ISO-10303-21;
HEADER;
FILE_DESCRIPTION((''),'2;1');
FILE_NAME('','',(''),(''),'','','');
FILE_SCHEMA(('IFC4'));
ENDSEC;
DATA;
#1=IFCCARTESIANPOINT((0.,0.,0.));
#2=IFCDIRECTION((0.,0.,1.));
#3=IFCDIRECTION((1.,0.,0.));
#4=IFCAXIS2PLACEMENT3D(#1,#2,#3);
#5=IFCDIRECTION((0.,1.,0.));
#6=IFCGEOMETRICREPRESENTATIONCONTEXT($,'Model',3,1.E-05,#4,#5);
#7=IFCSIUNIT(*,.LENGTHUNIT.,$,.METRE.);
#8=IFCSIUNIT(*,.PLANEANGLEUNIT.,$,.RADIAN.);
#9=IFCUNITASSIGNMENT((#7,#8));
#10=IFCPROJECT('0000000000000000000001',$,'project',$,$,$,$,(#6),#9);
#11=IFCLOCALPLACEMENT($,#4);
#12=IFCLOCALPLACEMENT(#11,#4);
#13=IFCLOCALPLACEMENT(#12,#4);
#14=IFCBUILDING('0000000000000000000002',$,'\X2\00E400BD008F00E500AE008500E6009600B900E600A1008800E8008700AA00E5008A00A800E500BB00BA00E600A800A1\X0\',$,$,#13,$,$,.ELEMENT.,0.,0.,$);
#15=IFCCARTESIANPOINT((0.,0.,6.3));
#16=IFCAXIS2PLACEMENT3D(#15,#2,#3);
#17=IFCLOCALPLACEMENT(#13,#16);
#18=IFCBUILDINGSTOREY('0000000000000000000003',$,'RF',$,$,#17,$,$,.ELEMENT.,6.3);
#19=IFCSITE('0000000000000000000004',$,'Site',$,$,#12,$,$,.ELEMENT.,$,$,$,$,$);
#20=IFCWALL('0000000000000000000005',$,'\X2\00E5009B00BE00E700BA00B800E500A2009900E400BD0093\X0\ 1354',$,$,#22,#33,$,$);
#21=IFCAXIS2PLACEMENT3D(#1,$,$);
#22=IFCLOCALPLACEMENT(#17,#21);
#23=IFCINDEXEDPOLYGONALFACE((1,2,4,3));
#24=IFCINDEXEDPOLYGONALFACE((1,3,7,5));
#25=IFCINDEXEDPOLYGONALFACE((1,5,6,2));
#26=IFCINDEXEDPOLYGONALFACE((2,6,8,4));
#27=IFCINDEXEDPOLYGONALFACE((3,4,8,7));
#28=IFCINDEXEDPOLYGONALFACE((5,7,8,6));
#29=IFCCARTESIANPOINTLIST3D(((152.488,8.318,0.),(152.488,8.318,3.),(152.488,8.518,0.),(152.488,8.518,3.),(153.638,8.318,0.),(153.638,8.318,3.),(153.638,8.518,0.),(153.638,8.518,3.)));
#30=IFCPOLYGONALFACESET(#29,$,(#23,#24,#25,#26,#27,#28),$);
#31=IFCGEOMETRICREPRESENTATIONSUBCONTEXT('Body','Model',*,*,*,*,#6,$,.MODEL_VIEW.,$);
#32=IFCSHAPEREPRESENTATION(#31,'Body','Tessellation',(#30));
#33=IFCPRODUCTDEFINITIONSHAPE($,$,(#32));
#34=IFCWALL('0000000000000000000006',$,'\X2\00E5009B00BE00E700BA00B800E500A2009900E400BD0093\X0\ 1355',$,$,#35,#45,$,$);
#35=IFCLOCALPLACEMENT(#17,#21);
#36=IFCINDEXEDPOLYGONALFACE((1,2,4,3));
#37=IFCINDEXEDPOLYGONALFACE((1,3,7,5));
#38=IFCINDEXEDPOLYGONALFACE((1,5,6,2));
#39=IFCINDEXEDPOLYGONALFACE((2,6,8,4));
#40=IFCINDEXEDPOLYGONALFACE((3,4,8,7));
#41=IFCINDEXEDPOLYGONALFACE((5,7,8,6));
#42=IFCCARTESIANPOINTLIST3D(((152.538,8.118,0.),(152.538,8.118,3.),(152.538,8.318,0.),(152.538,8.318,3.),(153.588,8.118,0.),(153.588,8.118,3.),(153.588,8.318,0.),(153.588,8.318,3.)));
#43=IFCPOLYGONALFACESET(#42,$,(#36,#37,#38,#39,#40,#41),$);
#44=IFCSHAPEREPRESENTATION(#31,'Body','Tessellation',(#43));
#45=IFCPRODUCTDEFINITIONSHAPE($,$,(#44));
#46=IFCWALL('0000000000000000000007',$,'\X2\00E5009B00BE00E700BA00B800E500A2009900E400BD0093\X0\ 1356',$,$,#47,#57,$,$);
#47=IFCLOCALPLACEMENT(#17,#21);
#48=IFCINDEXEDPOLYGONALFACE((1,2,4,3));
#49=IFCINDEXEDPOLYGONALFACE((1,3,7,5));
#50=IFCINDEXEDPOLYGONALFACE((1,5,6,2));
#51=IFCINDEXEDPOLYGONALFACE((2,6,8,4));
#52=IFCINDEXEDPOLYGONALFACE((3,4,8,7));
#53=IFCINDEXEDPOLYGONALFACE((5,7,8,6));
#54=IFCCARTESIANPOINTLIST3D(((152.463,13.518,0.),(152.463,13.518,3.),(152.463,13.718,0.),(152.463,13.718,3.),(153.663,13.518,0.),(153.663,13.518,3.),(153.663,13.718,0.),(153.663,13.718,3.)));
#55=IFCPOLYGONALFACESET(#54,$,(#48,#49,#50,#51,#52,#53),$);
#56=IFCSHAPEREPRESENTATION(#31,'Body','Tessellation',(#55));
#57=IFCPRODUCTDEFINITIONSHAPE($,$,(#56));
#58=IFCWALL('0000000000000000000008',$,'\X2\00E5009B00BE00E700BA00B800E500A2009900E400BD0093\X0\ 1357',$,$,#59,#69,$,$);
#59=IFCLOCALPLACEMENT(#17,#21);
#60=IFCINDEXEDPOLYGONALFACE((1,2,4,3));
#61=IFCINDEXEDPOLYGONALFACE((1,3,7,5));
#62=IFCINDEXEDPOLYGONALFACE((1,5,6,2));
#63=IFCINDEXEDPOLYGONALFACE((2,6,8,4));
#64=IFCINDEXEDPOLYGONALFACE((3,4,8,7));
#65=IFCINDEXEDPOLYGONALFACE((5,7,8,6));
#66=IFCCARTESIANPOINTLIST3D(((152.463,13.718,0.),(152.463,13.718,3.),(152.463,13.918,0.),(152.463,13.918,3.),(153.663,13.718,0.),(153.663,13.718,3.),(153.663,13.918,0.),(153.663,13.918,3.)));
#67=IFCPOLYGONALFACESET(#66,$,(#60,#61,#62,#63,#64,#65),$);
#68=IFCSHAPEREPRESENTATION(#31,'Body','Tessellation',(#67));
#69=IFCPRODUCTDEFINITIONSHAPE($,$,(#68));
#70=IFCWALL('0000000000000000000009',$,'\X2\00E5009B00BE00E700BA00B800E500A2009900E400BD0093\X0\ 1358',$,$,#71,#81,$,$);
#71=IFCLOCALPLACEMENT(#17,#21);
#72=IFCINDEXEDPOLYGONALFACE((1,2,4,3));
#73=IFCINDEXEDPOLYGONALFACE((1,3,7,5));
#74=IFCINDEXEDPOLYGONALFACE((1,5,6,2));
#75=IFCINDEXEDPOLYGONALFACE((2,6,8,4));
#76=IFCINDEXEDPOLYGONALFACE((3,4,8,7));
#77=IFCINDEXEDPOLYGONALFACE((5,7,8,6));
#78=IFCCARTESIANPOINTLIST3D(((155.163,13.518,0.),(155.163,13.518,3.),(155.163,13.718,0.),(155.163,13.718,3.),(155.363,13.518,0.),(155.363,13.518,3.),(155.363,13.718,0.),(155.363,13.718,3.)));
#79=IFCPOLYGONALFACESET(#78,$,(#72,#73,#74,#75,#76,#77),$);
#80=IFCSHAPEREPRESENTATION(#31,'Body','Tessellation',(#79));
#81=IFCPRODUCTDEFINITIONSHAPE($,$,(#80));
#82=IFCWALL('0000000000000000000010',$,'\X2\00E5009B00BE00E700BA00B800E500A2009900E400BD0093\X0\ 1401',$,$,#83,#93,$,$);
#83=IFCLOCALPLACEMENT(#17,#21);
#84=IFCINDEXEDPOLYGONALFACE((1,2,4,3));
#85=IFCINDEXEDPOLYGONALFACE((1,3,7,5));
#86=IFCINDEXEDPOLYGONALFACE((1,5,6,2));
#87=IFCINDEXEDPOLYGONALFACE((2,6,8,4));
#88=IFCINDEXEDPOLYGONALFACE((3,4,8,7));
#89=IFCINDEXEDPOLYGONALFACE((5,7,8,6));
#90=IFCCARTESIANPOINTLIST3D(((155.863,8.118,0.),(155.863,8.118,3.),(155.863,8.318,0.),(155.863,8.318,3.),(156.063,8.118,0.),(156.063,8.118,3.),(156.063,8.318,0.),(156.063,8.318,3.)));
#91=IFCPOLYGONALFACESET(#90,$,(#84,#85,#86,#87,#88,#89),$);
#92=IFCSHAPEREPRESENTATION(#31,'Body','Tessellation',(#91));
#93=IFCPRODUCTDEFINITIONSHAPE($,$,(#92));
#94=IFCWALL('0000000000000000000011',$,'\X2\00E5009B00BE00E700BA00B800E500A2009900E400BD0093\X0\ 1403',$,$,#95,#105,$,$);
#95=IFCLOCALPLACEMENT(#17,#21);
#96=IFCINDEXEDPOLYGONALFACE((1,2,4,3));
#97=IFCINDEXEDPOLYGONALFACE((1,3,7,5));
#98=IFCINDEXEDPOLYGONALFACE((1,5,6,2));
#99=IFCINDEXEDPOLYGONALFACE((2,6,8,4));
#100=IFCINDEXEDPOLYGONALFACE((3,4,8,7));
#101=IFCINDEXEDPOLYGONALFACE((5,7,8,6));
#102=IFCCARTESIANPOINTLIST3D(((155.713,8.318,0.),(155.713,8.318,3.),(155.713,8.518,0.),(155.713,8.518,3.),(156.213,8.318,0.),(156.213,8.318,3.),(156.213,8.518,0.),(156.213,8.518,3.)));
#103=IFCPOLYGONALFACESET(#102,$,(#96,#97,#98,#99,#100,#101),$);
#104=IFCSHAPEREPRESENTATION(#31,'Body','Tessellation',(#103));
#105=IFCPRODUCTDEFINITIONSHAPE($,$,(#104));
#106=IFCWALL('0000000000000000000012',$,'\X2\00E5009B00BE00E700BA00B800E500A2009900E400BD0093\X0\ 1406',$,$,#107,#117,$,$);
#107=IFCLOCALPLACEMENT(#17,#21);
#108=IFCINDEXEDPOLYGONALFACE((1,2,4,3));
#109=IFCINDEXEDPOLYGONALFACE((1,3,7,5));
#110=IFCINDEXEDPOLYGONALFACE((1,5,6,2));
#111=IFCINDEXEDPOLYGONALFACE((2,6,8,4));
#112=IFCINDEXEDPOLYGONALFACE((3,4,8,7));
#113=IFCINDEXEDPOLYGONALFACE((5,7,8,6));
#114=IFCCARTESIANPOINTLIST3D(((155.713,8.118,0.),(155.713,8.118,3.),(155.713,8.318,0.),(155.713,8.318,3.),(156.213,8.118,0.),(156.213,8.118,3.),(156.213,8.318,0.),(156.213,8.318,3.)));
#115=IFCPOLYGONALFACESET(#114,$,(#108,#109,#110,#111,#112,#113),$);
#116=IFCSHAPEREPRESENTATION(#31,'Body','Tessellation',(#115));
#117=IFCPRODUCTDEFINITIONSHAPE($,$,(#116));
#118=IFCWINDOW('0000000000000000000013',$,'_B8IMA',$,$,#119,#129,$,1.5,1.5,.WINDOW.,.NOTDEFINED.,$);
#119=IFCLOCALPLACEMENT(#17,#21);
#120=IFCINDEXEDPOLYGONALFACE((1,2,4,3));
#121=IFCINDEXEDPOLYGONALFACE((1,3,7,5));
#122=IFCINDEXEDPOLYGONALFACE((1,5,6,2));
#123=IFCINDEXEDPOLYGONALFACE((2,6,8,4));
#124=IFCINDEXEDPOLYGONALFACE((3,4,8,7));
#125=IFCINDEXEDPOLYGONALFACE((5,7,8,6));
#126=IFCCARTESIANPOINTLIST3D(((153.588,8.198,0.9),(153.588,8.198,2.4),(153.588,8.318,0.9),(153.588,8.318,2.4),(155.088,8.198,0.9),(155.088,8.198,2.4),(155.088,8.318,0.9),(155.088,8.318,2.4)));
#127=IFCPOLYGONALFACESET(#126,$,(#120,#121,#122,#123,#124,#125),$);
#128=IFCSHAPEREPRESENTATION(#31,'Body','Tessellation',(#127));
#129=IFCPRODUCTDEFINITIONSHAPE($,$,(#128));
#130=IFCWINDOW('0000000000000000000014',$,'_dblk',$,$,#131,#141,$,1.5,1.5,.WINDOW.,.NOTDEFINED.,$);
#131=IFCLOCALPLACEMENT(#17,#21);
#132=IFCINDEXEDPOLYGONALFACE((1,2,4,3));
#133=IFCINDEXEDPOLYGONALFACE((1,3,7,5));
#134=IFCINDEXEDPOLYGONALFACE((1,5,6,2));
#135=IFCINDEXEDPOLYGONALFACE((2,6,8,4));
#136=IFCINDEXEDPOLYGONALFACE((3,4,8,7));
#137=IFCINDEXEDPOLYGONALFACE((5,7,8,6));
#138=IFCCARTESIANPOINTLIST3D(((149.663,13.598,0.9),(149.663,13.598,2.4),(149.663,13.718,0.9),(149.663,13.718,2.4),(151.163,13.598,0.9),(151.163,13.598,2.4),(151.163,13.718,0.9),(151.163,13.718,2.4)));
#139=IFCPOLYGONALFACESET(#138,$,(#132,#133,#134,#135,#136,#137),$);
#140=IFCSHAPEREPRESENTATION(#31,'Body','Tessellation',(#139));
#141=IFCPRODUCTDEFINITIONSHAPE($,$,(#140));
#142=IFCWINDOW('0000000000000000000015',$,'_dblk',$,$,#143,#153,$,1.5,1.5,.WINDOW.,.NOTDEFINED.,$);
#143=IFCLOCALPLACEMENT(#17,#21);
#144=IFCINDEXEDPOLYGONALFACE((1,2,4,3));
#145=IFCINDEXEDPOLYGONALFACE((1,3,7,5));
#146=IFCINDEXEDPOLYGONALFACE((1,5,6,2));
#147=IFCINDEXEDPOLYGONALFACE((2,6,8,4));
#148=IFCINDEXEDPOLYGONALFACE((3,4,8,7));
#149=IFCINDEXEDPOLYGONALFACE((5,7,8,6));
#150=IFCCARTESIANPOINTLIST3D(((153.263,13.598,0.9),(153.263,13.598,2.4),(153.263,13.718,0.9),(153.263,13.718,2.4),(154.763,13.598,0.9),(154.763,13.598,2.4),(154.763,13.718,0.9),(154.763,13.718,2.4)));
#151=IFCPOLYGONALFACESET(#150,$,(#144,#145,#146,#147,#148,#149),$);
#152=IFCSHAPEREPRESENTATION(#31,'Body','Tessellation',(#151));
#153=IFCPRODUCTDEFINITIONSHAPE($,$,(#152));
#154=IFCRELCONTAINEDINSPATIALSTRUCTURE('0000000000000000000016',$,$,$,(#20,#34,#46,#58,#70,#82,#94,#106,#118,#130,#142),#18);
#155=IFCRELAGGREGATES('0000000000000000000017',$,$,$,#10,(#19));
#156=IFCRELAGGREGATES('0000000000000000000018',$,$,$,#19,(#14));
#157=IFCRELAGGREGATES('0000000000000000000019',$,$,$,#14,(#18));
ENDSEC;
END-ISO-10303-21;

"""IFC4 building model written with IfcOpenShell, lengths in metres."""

from ifc_helpers import new_model, si_unit, direction, frame, frame_2d, origin_with_axes, place, context, subcontext, project, spatial, rectangle, extrude, element, save


model = new_model("IFC4")

# Units and contexts
model_context = context("Model", 3, precision=1e-05, world=origin_with_axes(), true_north=direction((0.0, 1.0, 0.0)))
body_context = subcontext(model_context, "Body", "Model", "MODEL_VIEW")
ifc_project = project(units=[si_unit("LENGTHUNIT", "METRE"), si_unit("PLANEANGLEUNIT", "RADIAN")], contexts=[model_context])

# Site, building, storey
placement = place(None, origin_with_axes())
site_placement = place(placement, origin_with_axes())
site = spatial("IfcSite", under=ifc_project, at=site_placement, Name="Site", CompositionType="ELEMENT")
building_placement = place(site_placement, origin_with_axes())
building = spatial("IfcBuilding", under=site, at=building_placement, Name="ä½\u008få®\u0085æ\u0096¹æ¡\u0088è\u0087ªå\u008a¨å»ºæ¨¡", CompositionType="ELEMENT", ElevationOfRefHeight=0.0, ElevationOfTerrain=0.0)
storey_placement = place(building_placement, frame((0.0, 0.0, 6.3), z_axis=(0.0, 0.0, 1.0), x_axis=(1.0, 0.0, 0.0)))
storey = spatial("IfcBuildingStorey", under=building, at=storey_placement, Name="RF", CompositionType="ELEMENT", Elevation=6.3)

# Walls
wall_1_placement = place(storey_placement, frame((153.063, 8.418, 0.0), z_axis=(0.0, 0.0, 1.0), x_axis=(1.0, 0.0, 0.0)))
element("IfcWall", 1, at=wall_1_placement, inside=storey, Name="å\u009b¾çº¸å¢\u0099ä½\u0093 1354", context=body_context, shape_type="SweptSolid", body=[
    extrude(rectangle(XDim=1.15, YDim=0.2, at=frame_2d((0.0, 0.0), x_axis=(1.0, 0.0, 0.0))), frame((0.0, 0.0, 0.0), z_axis=(0.0, 0.0, 1.0)), (0.0, 0.0, 1.0), 3.0),
])
wall_2_placement = place(storey_placement, frame((153.063, 8.218, 0.0), z_axis=(0.0, 0.0, 1.0), x_axis=(1.0, 0.0, 0.0)))
element("IfcWall", 2, at=wall_2_placement, inside=storey, Name="å\u009b¾çº¸å¢\u0099ä½\u0093 1355", context=body_context, shape_type="SweptSolid", body=[
    extrude(rectangle(XDim=1.05, YDim=0.2, at=frame_2d((0.0, 0.0), x_axis=(1.0, 0.0, 0.0))), frame((0.0, 0.0, 0.0), z_axis=(0.0, 0.0, 1.0)), (0.0, 0.0, 1.0), 3.0),
])
for number, where, z_axis, x_axis, name in (
    (3, (153.063, 13.618, 0.0), (0.0, 0.0, 1.0), (1.0, 0.0, 0.0), "å\u009b¾çº¸å¢\u0099ä½\u0093 1356"),
    (4, (153.063, 13.818, 0.0), (0.0, 0.0, 1.0), (1.0, 0.0, 0.0), "å\u009b¾çº¸å¢\u0099ä½\u0093 1357"),
):
    element("IfcWall", number, at=place(storey_placement, frame(where, z_axis=z_axis, x_axis=x_axis)), inside=storey, Name=name, context=body_context, shape_type="SweptSolid", body=[
        extrude(rectangle(XDim=1.2, YDim=0.2, at=frame_2d((0.0, 0.0), x_axis=(1.0, 0.0, 0.0))), frame((0.0, 0.0, 0.0), z_axis=(0.0, 0.0, 1.0)), (0.0, 0.0, 1.0), 3.0),
    ])
for number, where, z_axis, x_axis, name in (
    (5, (155.263, 13.618, 0.0), (0.0, 0.0, 1.0), (0.0, 1.0, 0.0), "å\u009b¾çº¸å¢\u0099ä½\u0093 1358"),
    (6, (155.963, 8.218, 0.0), (0.0, 0.0, 1.0), (0.0, 1.0, 0.0), "å\u009b¾çº¸å¢\u0099ä½\u0093 1401"),
):
    element("IfcWall", number, at=place(storey_placement, frame(where, z_axis=z_axis, x_axis=x_axis)), inside=storey, Name=name, context=body_context, shape_type="SweptSolid", body=[
        extrude(rectangle(XDim=0.2, YDim=0.2, at=frame_2d((0.0, 0.0), x_axis=(1.0, 0.0, 0.0))), frame((0.0, 0.0, 0.0), z_axis=(0.0, 0.0, 1.0)), (0.0, 0.0, 1.0), 3.0),
    ])
for number, where, z_axis, x_axis, name in (
    (7, (155.963, 8.418, 0.0), (0.0, 0.0, 1.0), (1.0, 0.0, 0.0), "å\u009b¾çº¸å¢\u0099ä½\u0093 1403"),
    (8, (155.963, 8.218, 0.0), (0.0, 0.0, 1.0), (1.0, 0.0, 0.0), "å\u009b¾çº¸å¢\u0099ä½\u0093 1406"),
):
    element("IfcWall", number, at=place(storey_placement, frame(where, z_axis=z_axis, x_axis=x_axis)), inside=storey, Name=name, context=body_context, shape_type="SweptSolid", body=[
        extrude(rectangle(XDim=0.5, YDim=0.2, at=frame_2d((0.0, 0.0), x_axis=(1.0, 0.0, 0.0))), frame((0.0, 0.0, 0.0), z_axis=(0.0, 0.0, 1.0)), (0.0, 0.0, 1.0), 3.0),
    ])

# Windows
for number, where, z_axis, x_axis, name in (
    (9, (154.338, 8.258, 0.9), (0.0, 0.0, 1.0), (1.0, 0.0, 0.0), "_B8IMA"),
    (10, (150.413, 13.658, 0.9), (0.0, 0.0, 1.0), (1.0, 0.0, 0.0), "_dblk"),
    (11, (154.013, 13.658, 0.9), (0.0, 0.0, 1.0), (1.0, 0.0, 0.0), "_dblk"),
):
    element("IfcWindow", number, at=place(storey_placement, frame(where, z_axis=z_axis, x_axis=x_axis)), inside=storey, Name=name, OverallHeight=1.5, OverallWidth=1.5, PartitioningType="NOTDEFINED", PredefinedType="WINDOW", context=body_context, shape_type="SweptSolid", body=[
        extrude(rectangle(XDim=1.5, YDim=0.12, at=frame_2d((0.0, 0.0), x_axis=(1.0, 0.0, 0.0))), frame((0.0, 0.0, 0.0), z_axis=(0.0, 0.0, 1.0)), (0.0, 0.0, 1.0), 1.5),
    ])

save(model, "model.ifc")
